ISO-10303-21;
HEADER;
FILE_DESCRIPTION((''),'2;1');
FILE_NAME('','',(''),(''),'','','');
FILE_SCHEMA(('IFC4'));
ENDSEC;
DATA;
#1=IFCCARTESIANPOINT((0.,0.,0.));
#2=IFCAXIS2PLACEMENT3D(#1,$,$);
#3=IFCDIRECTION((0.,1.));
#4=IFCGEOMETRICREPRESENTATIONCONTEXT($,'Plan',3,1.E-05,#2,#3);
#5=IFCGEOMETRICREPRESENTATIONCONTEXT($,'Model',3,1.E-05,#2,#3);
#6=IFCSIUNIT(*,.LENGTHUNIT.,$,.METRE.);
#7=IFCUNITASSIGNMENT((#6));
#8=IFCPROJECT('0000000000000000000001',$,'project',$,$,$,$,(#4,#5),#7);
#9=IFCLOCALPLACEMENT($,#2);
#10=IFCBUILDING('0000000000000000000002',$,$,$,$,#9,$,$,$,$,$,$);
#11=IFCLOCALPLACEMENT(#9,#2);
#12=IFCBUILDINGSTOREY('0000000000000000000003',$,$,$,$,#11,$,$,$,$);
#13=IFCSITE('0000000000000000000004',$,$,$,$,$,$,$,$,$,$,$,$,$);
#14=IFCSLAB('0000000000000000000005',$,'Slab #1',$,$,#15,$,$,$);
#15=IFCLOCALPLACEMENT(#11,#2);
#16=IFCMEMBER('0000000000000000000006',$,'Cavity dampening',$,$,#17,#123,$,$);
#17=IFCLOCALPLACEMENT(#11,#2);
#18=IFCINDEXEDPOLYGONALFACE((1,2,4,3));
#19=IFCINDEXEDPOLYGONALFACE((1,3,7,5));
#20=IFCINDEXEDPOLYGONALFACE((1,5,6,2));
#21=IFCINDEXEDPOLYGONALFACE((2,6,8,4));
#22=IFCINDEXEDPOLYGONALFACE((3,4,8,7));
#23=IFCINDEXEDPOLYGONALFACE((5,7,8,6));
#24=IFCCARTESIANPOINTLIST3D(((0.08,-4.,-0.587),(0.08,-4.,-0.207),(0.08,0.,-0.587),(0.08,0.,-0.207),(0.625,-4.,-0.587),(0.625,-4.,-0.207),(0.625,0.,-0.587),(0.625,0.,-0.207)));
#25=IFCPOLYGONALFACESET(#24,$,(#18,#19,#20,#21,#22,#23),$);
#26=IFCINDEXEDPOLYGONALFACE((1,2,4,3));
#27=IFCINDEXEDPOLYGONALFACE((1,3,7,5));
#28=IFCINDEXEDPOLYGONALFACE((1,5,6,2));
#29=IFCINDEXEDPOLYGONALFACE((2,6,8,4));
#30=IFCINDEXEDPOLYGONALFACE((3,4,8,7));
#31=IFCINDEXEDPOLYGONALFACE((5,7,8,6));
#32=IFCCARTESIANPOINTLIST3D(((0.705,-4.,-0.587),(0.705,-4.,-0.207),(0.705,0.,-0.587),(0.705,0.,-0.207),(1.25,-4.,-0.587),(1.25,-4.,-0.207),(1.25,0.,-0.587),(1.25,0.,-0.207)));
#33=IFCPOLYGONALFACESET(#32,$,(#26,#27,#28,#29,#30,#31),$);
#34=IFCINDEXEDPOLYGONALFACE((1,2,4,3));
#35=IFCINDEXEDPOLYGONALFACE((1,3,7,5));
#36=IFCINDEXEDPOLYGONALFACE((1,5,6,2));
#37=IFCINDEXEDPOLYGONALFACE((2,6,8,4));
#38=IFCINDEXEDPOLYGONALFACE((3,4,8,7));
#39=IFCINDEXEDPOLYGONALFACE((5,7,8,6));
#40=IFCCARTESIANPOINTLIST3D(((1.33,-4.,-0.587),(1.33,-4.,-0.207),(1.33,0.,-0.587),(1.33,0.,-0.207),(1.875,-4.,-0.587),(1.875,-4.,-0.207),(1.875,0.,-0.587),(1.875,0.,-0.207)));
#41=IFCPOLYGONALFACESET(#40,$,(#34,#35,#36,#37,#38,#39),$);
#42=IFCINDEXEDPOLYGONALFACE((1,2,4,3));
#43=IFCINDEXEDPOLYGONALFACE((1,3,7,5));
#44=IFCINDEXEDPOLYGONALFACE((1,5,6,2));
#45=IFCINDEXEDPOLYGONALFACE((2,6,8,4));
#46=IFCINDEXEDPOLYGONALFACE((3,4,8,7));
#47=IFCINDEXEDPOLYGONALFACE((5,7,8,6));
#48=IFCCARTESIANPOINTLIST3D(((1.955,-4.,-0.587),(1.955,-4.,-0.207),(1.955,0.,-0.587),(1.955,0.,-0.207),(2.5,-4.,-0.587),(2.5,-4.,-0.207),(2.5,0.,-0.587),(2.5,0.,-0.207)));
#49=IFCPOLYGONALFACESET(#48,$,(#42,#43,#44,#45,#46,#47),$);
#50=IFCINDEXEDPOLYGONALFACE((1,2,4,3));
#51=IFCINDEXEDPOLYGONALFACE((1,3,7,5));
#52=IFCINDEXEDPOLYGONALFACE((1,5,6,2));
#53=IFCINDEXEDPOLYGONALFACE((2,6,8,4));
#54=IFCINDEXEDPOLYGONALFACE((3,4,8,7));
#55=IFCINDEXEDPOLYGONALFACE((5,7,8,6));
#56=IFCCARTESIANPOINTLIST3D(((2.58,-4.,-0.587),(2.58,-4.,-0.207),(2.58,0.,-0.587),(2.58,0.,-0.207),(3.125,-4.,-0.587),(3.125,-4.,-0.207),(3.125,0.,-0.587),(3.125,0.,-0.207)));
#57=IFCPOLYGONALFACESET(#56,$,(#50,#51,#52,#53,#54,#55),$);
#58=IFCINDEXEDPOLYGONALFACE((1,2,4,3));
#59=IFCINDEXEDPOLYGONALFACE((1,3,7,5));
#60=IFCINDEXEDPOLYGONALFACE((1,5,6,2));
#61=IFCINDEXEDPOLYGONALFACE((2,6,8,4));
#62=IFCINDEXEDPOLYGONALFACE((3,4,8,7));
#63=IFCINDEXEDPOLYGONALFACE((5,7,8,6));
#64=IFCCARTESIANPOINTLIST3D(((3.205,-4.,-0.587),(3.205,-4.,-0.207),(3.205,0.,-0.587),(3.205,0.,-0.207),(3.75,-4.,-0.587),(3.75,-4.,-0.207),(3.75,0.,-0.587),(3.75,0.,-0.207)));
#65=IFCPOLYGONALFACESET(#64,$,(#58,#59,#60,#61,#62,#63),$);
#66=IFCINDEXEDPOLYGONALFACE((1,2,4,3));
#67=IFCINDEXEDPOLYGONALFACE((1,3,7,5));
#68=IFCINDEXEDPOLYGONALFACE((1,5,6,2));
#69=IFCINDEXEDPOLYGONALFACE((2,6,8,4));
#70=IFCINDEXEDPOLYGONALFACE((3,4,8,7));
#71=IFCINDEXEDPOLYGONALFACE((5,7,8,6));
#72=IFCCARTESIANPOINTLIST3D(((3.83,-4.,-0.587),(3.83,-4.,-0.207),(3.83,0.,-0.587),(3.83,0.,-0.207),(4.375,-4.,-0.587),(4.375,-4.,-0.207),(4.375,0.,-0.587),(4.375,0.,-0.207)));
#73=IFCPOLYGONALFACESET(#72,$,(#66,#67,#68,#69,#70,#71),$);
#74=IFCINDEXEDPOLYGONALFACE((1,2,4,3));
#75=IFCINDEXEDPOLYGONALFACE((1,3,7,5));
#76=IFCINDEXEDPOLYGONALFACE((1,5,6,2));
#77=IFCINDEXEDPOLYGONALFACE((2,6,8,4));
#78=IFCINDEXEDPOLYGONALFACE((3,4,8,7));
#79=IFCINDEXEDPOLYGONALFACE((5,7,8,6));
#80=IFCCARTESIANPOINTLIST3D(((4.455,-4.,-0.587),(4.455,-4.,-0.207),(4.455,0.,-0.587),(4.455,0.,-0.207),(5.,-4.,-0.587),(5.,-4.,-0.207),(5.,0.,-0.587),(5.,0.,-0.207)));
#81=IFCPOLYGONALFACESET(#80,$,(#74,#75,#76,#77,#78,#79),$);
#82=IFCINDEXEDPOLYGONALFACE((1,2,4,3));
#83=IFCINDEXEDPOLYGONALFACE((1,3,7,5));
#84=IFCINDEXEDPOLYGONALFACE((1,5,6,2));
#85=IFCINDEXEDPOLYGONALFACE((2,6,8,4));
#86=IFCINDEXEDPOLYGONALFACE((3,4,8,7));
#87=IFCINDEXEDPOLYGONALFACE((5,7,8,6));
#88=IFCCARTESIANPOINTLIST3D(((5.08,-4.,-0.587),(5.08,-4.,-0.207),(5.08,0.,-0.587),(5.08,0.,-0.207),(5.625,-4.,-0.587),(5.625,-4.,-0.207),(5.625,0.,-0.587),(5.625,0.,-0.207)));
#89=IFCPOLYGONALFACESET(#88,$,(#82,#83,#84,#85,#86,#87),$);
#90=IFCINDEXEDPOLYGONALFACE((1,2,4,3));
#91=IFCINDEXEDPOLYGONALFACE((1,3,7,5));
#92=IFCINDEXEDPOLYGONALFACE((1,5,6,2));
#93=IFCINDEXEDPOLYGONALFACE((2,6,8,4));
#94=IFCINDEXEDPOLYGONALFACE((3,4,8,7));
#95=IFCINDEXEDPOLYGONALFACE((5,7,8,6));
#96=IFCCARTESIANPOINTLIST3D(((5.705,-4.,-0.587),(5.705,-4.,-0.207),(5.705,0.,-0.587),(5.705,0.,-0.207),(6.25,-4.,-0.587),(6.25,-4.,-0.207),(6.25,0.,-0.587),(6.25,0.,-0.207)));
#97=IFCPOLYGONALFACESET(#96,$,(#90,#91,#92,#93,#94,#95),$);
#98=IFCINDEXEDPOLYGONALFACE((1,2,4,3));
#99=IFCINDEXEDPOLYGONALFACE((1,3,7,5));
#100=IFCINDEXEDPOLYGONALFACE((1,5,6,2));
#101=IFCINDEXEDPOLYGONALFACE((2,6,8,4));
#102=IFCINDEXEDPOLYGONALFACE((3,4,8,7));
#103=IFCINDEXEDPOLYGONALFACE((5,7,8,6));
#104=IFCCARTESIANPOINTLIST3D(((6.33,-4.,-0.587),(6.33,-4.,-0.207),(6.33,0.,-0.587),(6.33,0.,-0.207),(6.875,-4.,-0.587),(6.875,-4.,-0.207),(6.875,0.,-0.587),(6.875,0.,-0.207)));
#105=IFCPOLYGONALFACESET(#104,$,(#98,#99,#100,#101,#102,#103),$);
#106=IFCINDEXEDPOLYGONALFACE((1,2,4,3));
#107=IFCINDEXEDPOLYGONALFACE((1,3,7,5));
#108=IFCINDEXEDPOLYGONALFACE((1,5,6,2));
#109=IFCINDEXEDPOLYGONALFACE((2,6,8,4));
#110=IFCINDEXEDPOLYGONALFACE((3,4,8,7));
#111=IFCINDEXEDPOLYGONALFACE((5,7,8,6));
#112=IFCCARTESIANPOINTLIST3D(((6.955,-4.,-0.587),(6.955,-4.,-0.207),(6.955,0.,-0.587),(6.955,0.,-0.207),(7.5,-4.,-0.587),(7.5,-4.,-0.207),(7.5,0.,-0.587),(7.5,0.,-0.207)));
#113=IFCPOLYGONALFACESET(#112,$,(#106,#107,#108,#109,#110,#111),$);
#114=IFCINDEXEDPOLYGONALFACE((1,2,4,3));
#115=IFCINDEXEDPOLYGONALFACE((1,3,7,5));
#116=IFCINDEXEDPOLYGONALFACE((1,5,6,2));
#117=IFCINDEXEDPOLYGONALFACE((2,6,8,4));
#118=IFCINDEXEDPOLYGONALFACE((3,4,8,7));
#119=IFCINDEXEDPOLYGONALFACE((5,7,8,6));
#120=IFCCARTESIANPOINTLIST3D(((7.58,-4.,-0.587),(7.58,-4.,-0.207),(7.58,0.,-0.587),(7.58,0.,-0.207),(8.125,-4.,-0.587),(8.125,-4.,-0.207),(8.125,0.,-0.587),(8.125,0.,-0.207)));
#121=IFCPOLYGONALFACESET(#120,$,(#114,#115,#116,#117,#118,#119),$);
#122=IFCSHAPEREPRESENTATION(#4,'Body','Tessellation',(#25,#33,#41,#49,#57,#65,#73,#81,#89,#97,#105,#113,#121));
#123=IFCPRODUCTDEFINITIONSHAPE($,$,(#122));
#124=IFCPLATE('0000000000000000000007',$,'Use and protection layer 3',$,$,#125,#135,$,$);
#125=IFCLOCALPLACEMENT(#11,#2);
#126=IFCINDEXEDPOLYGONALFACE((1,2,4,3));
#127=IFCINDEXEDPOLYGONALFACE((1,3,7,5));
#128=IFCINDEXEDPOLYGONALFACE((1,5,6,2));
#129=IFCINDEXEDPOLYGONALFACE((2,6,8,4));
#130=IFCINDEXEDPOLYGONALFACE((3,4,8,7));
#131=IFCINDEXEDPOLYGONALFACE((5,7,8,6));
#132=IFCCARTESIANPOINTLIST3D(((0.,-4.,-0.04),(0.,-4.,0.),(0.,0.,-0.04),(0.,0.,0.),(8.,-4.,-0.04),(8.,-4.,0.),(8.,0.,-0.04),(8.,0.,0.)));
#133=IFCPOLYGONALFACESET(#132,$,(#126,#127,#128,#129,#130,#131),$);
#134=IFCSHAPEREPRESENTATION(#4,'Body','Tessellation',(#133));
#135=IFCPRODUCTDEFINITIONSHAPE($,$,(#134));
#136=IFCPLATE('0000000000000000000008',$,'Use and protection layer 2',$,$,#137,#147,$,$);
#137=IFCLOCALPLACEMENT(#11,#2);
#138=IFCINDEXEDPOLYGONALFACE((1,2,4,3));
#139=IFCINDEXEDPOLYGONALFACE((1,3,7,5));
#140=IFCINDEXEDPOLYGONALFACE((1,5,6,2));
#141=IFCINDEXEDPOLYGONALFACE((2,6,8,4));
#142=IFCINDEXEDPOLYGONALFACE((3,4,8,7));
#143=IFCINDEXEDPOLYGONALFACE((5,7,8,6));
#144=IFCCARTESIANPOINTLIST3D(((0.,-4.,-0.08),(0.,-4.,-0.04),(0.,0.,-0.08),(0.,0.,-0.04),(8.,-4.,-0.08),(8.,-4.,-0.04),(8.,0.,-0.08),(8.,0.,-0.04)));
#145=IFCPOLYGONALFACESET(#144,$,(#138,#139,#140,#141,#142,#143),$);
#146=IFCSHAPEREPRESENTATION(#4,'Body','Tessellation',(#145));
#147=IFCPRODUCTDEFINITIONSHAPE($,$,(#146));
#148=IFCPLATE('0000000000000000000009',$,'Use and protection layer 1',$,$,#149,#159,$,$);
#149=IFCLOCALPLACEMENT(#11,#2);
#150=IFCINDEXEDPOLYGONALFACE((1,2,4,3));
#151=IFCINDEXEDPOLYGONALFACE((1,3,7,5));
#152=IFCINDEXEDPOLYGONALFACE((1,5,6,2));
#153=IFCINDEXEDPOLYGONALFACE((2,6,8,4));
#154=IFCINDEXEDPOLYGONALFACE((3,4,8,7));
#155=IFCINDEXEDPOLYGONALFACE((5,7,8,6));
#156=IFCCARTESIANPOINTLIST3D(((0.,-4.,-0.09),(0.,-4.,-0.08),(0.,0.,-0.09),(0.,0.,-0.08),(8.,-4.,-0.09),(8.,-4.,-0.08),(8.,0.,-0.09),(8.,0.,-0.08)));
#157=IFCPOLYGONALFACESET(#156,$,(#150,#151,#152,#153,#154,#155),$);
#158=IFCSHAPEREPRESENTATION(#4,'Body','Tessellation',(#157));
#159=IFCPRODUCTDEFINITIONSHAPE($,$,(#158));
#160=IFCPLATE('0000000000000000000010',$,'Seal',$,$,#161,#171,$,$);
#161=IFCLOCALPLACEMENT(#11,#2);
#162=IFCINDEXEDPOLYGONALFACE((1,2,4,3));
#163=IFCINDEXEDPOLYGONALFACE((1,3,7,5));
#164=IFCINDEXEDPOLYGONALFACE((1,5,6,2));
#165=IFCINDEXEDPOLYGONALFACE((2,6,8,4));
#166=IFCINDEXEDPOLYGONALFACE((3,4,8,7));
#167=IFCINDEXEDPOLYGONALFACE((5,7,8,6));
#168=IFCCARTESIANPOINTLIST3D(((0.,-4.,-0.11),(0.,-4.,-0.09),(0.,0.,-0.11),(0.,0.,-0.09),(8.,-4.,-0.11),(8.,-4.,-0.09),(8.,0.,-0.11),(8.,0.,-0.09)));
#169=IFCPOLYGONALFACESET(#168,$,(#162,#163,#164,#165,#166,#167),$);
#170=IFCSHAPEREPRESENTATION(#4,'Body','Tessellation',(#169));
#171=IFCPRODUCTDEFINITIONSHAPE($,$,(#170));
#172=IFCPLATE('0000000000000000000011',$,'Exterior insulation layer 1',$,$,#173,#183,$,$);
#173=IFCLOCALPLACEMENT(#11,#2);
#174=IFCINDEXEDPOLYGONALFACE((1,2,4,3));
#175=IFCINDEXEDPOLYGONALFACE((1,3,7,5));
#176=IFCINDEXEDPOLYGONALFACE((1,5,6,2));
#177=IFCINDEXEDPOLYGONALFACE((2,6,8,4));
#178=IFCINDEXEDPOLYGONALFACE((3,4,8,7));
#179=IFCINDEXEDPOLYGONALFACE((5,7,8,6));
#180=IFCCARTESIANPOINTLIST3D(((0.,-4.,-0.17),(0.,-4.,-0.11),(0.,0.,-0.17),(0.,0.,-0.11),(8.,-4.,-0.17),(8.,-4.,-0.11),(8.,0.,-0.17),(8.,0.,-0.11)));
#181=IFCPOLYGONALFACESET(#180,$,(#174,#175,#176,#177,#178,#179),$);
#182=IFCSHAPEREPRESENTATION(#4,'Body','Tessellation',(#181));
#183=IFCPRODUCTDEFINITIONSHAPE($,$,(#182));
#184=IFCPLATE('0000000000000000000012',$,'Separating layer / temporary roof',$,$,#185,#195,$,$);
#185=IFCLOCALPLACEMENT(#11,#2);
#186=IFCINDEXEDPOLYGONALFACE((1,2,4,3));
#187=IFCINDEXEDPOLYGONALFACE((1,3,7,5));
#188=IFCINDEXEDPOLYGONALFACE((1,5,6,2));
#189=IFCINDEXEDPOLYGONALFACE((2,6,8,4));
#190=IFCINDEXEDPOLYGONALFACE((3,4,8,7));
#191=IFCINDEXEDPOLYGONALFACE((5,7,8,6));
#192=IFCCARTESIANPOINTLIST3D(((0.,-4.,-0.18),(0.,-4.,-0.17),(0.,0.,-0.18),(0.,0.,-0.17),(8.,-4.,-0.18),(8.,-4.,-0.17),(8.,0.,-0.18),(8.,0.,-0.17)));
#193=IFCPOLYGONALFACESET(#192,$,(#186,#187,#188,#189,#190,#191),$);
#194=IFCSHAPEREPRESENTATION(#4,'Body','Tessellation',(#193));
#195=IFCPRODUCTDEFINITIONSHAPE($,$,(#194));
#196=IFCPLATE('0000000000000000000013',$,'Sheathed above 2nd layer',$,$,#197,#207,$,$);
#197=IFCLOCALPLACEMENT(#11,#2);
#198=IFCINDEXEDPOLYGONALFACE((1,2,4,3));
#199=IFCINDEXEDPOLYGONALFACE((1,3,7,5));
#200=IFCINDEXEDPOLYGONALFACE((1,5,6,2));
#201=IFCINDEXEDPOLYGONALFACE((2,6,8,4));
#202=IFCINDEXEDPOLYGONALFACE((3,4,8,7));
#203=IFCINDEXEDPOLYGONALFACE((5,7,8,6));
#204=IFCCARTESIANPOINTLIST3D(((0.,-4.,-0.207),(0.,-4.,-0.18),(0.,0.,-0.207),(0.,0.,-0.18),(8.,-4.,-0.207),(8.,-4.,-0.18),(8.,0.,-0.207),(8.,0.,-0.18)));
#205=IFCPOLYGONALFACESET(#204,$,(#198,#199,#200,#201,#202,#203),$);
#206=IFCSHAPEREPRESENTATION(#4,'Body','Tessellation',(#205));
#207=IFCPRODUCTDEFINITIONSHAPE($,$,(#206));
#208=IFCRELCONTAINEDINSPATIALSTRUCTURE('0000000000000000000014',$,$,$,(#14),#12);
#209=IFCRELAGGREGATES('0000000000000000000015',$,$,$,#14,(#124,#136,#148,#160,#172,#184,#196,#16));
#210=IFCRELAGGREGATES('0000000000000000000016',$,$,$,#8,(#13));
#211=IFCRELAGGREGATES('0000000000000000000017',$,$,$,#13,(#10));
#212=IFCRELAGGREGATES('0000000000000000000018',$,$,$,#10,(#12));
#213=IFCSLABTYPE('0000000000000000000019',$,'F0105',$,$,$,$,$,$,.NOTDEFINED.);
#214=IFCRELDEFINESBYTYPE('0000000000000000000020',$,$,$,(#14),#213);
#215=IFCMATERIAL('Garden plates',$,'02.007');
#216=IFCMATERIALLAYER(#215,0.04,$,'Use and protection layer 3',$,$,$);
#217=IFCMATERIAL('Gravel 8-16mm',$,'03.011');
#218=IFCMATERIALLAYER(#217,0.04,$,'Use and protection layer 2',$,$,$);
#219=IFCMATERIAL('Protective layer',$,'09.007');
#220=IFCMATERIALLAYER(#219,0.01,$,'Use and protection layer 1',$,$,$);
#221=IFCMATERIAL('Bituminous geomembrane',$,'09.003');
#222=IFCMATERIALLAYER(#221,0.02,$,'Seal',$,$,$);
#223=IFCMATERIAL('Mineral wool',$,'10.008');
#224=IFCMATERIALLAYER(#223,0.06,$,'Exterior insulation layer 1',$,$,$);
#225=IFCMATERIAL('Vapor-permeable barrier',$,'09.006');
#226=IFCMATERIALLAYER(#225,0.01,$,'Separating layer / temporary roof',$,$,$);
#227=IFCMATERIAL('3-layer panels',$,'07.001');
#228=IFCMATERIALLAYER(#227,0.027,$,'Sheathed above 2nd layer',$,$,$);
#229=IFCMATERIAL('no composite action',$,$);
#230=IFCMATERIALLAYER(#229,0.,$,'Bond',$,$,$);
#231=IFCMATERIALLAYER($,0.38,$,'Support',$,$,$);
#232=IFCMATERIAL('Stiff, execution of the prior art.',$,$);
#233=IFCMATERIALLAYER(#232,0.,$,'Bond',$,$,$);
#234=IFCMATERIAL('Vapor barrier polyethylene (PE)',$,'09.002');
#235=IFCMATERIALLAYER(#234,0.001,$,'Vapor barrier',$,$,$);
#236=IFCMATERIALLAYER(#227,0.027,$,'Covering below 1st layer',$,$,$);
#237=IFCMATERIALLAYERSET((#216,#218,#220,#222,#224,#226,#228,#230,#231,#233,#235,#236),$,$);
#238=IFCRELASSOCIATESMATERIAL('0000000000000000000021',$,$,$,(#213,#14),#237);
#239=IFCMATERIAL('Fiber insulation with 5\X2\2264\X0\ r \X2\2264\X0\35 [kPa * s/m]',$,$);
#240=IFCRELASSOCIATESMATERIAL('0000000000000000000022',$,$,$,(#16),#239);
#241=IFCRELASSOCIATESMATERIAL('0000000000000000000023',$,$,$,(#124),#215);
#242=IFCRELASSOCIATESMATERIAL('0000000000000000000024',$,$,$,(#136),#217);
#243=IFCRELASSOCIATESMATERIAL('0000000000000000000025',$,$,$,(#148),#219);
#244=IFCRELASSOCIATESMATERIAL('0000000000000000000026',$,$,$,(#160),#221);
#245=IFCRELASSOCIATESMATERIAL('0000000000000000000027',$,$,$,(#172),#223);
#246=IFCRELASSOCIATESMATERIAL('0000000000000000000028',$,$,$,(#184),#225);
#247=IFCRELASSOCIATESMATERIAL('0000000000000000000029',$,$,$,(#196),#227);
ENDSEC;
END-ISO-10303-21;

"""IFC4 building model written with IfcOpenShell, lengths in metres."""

from ifc_helpers import new_model, si_unit, direction, frame, frame_2d, origin, origin_with_axes, place, context, project, spatial, rectangle, extrude, material, layer, layer_set, type_object, element, aggregate, save


model = new_model("IFC4")

# Units and contexts
plan_context = context("Plan", 3, precision=1e-05, world=origin(), true_north=direction((0.0, 1.0)))
model_context = context("Model", 3, precision=1e-05, world=origin(), true_north=direction((0.0, 1.0)))
ifc_project = project(units=[si_unit("LENGTHUNIT", "METRE")], contexts=[plan_context, model_context])

# Site, building, storey
site = spatial("IfcSite", under=ifc_project)
building_placement = place(None, origin())
building = spatial("IfcBuilding", under=site, at=building_placement)
storey_placement = place(building_placement, origin())
storey = spatial("IfcBuildingStorey", under=building, at=storey_placement)

# Slab, member, plates
ifc_material_1 = material(Name="Garden plates", Category="02.007")
ifc_layer_1 = layer(ifc_material_1, 0.04, Name="Use and protection layer 3")
ifc_material_2 = material(Name="Gravel 8-16mm", Category="03.011")
ifc_layer_2 = layer(ifc_material_2, 0.04, Name="Use and protection layer 2")
ifc_material_3 = material(Name="Protective layer", Category="09.007")
ifc_layer_3 = layer(ifc_material_3, 0.01, Name="Use and protection layer 1")
ifc_material_4 = material(Name="Bituminous geomembrane", Category="09.003")
ifc_layer_4 = layer(ifc_material_4, 0.02, Name="Seal")
ifc_material_5 = material(Name="Mineral wool", Category="10.008")
ifc_layer_5 = layer(ifc_material_5, 0.06, Name="Exterior insulation layer 1")
ifc_material_6 = material(Name="Vapor-permeable barrier", Category="09.006")
ifc_layer_6 = layer(ifc_material_6, 0.01, Name="Separating layer / temporary roof")
ifc_material_7 = material(Name="3-layer panels", Category="07.001")
ifc_layer_7 = layer(ifc_material_7, 0.027, Name="Sheathed above 2nd layer")
ifc_material_8 = material(Name="no composite action")
ifc_layer_8 = layer(ifc_material_8, 0.0, Name="Bond")
ifc_layer_9 = layer(None, 0.38, Name="Support")
ifc_material_9 = material(Name="Stiff, execution of the prior art.")
ifc_layer_10 = layer(ifc_material_9, 0.0, Name="Bond")
ifc_material_10 = material(Name="Vapor barrier polyethylene (PE)", Category="09.002")
ifc_layer_11 = layer(ifc_material_10, 0.001, Name="Vapor barrier")
ifc_layer_12 = layer(ifc_material_7, 0.027, Name="Covering below 1st layer")
ifc_layer_set = layer_set([ifc_layer_1, ifc_layer_2, ifc_layer_3, ifc_layer_4, ifc_layer_5, ifc_layer_6, ifc_layer_7, ifc_layer_8, ifc_layer_9, ifc_layer_10, ifc_layer_11, ifc_layer_12])
slab_type = type_object("IfcSlabType", Name="F0105", PredefinedType="NOTDEFINED", material=ifc_layer_set)
slab_placement = place(None, frame((0.0, 0.0, 0.0), z_axis=(0.0, 0.0, -1.0), x_axis=(1.0, 0.0, 0.0)))
slab = element("IfcSlab", 1, at=slab_placement, inside=storey, type_object=slab_type, material=ifc_layer_set, Name="Slab #1")
ifc_material_11 = material(Name="Fiber insulation with 5≤ r ≤35 [kPa * s/m]")
member_1_placement = place(slab_placement, origin())
member_1 = element("IfcMember", 2, at=member_1_placement, material=ifc_material_11, Name="Cavity dampening", context=plan_context, shape_type="SweptSolid", body=[
    extrude(rectangle(XDim=0.545, YDim=0.38, at=frame_2d((0.2725, 0.19), x_axis=(1.0, 0.0))), frame((0.08, 4.0, 0.207), z_axis=(0.0, -1.0, 0.0), x_axis=(1.0, 0.0, 0.0)), (0.0, 0.0, 1.0), 4.0),
    extrude(rectangle(XDim=0.545, YDim=0.38, at=frame_2d((0.2725, 0.19), x_axis=(1.0, 0.0))), frame((0.705, 4.0, 0.207), z_axis=(0.0, -1.0, 0.0), x_axis=(1.0, 0.0, 0.0)), (0.0, 0.0, 1.0), 4.0),
    extrude(rectangle(XDim=0.545, YDim=0.38, at=frame_2d((0.2725, 0.19), x_axis=(1.0, 0.0))), frame((1.33, 4.0, 0.207), z_axis=(0.0, -1.0, 0.0), x_axis=(1.0, 0.0, 0.0)), (0.0, 0.0, 1.0), 4.0),
    extrude(rectangle(XDim=0.545, YDim=0.38, at=frame_2d((0.2725, 0.19), x_axis=(1.0, 0.0))), frame((1.955, 4.0, 0.207), z_axis=(0.0, -1.0, 0.0), x_axis=(1.0, 0.0, 0.0)), (0.0, 0.0, 1.0), 4.0),
    extrude(rectangle(XDim=0.545, YDim=0.38, at=frame_2d((0.2725, 0.19), x_axis=(1.0, 0.0))), frame((2.58, 4.0, 0.207), z_axis=(0.0, -1.0, 0.0), x_axis=(1.0, 0.0, 0.0)), (0.0, 0.0, 1.0), 4.0),
    extrude(rectangle(XDim=0.545, YDim=0.38, at=frame_2d((0.2725, 0.19), x_axis=(1.0, 0.0))), frame((3.205, 4.0, 0.207), z_axis=(0.0, -1.0, 0.0), x_axis=(1.0, 0.0, 0.0)), (0.0, 0.0, 1.0), 4.0),
    extrude(rectangle(XDim=0.545, YDim=0.38, at=frame_2d((0.2725, 0.19), x_axis=(1.0, 0.0))), frame((3.83, 4.0, 0.207), z_axis=(0.0, -1.0, 0.0), x_axis=(1.0, 0.0, 0.0)), (0.0, 0.0, 1.0), 4.0),
    extrude(rectangle(XDim=0.545, YDim=0.38, at=frame_2d((0.2725, 0.19), x_axis=(1.0, 0.0))), frame((4.455, 4.0, 0.207), z_axis=(0.0, -1.0, 0.0), x_axis=(1.0, 0.0, 0.0)), (0.0, 0.0, 1.0), 4.0),
    extrude(rectangle(XDim=0.545, YDim=0.38, at=frame_2d((0.2725, 0.19), x_axis=(1.0, 0.0))), frame((5.08, 4.0, 0.207), z_axis=(0.0, -1.0, 0.0), x_axis=(1.0, 0.0, 0.0)), (0.0, 0.0, 1.0), 4.0),
    extrude(rectangle(XDim=0.545, YDim=0.38, at=frame_2d((0.2725, 0.19), x_axis=(1.0, 0.0))), frame((5.705, 4.0, 0.207), z_axis=(0.0, -1.0, 0.0), x_axis=(1.0, 0.0, 0.0)), (0.0, 0.0, 1.0), 4.0),
    extrude(rectangle(XDim=0.545, YDim=0.38, at=frame_2d((0.2725, 0.19), x_axis=(1.0, 0.0))), frame((6.33, 4.0, 0.207), z_axis=(0.0, -1.0, 0.0), x_axis=(1.0, 0.0, 0.0)), (0.0, 0.0, 1.0), 4.0),
    extrude(rectangle(XDim=0.545, YDim=0.38, at=frame_2d((0.2725, 0.19), x_axis=(1.0, 0.0))), frame((6.955, 4.0, 0.207), z_axis=(0.0, -1.0, 0.0), x_axis=(1.0, 0.0, 0.0)), (0.0, 0.0, 1.0), 4.0),
    extrude(rectangle(XDim=0.545, YDim=0.38, at=frame_2d((0.2725, 0.19), x_axis=(1.0, 0.0))), frame((7.58, 4.0, 0.207), z_axis=(0.0, -1.0, 0.0), x_axis=(1.0, 0.0, 0.0)), (0.0, 0.0, 1.0), 4.0),
])
plate_1_placement = place(slab_placement, origin())
plate_1 = element("IfcPlate", 3, at=plate_1_placement, material=ifc_material_1, Name="Use and protection layer 3", context=plan_context, shape_type="SweptSolid", body=[
    extrude(rectangle(XDim=8.0, YDim=4.0, at=frame_2d((4.0, 2.0), x_axis=(1.0, 0.0))), origin_with_axes(), (0.0, 0.0, 1.0), 0.04),
])
plate_2_placement = place(slab_placement, origin())
plate_2 = element("IfcPlate", 4, at=plate_2_placement, material=ifc_material_2, Name="Use and protection layer 2", context=plan_context, shape_type="SweptSolid", body=[
    extrude(rectangle(XDim=8.0, YDim=4.0, at=frame_2d((4.0, 2.0), x_axis=(1.0, 0.0))), frame((0.0, 0.0, 0.04), z_axis=(0.0, 0.0, 1.0), x_axis=(1.0, 0.0, 0.0)), (0.0, 0.0, 1.0), 0.04),
])
plate_3_placement = place(slab_placement, origin())
plate_3 = element("IfcPlate", 5, at=plate_3_placement, material=ifc_material_3, Name="Use and protection layer 1", context=plan_context, shape_type="SweptSolid", body=[
    extrude(rectangle(XDim=8.0, YDim=4.0, at=frame_2d((4.0, 2.0), x_axis=(1.0, 0.0))), frame((0.0, 0.0, 0.08), z_axis=(0.0, 0.0, 1.0), x_axis=(1.0, 0.0, 0.0)), (0.0, 0.0, 1.0), 0.01),
])
plate_4_placement = place(slab_placement, origin())
plate_4 = element("IfcPlate", 6, at=plate_4_placement, material=ifc_material_4, Name="Seal", context=plan_context, shape_type="SweptSolid", body=[
    extrude(rectangle(XDim=8.0, YDim=4.0, at=frame_2d((4.0, 2.0), x_axis=(1.0, 0.0))), frame((0.0, 0.0, 0.09), z_axis=(0.0, 0.0, 1.0), x_axis=(1.0, 0.0, 0.0)), (0.0, 0.0, 1.0), 0.02),
])
plate_5_placement = place(slab_placement, origin())
plate_5 = element("IfcPlate", 7, at=plate_5_placement, material=ifc_material_5, Name="Exterior insulation layer 1", context=plan_context, shape_type="SweptSolid", body=[
    extrude(rectangle(XDim=8.0, YDim=4.0, at=frame_2d((4.0, 2.0), x_axis=(1.0, 0.0))), frame((0.0, 0.0, 0.11), z_axis=(0.0, 0.0, 1.0), x_axis=(1.0, 0.0, 0.0)), (0.0, 0.0, 1.0), 0.06),
])
plate_6_placement = place(slab_placement, origin())
plate_6 = element("IfcPlate", 8, at=plate_6_placement, material=ifc_material_6, Name="Separating layer / temporary roof", context=plan_context, shape_type="SweptSolid", body=[
    extrude(rectangle(XDim=8.0, YDim=4.0, at=frame_2d((4.0, 2.0), x_axis=(1.0, 0.0))), frame((0.0, 0.0, 0.17), z_axis=(0.0, 0.0, 1.0), x_axis=(1.0, 0.0, 0.0)), (0.0, 0.0, 1.0), 0.01),
])
plate_7_placement = place(slab_placement, origin())
plate_7 = element("IfcPlate", 9, at=plate_7_placement, material=ifc_material_7, Name="Sheathed above 2nd layer", context=plan_context, shape_type="SweptSolid", body=[
    extrude(rectangle(XDim=8.0, YDim=4.0, at=frame_2d((4.0, 2.0), x_axis=(1.0, 0.0))), frame((0.0, 0.0, 0.18), z_axis=(0.0, 0.0, 1.0), x_axis=(1.0, 0.0, 0.0)), (0.0, 0.0, 1.0), 0.027),
])
aggregate(slab, [plate_1, plate_2, plate_3, plate_4, plate_5, plate_6, plate_7, member_1])

save(model, "model.ifc")
